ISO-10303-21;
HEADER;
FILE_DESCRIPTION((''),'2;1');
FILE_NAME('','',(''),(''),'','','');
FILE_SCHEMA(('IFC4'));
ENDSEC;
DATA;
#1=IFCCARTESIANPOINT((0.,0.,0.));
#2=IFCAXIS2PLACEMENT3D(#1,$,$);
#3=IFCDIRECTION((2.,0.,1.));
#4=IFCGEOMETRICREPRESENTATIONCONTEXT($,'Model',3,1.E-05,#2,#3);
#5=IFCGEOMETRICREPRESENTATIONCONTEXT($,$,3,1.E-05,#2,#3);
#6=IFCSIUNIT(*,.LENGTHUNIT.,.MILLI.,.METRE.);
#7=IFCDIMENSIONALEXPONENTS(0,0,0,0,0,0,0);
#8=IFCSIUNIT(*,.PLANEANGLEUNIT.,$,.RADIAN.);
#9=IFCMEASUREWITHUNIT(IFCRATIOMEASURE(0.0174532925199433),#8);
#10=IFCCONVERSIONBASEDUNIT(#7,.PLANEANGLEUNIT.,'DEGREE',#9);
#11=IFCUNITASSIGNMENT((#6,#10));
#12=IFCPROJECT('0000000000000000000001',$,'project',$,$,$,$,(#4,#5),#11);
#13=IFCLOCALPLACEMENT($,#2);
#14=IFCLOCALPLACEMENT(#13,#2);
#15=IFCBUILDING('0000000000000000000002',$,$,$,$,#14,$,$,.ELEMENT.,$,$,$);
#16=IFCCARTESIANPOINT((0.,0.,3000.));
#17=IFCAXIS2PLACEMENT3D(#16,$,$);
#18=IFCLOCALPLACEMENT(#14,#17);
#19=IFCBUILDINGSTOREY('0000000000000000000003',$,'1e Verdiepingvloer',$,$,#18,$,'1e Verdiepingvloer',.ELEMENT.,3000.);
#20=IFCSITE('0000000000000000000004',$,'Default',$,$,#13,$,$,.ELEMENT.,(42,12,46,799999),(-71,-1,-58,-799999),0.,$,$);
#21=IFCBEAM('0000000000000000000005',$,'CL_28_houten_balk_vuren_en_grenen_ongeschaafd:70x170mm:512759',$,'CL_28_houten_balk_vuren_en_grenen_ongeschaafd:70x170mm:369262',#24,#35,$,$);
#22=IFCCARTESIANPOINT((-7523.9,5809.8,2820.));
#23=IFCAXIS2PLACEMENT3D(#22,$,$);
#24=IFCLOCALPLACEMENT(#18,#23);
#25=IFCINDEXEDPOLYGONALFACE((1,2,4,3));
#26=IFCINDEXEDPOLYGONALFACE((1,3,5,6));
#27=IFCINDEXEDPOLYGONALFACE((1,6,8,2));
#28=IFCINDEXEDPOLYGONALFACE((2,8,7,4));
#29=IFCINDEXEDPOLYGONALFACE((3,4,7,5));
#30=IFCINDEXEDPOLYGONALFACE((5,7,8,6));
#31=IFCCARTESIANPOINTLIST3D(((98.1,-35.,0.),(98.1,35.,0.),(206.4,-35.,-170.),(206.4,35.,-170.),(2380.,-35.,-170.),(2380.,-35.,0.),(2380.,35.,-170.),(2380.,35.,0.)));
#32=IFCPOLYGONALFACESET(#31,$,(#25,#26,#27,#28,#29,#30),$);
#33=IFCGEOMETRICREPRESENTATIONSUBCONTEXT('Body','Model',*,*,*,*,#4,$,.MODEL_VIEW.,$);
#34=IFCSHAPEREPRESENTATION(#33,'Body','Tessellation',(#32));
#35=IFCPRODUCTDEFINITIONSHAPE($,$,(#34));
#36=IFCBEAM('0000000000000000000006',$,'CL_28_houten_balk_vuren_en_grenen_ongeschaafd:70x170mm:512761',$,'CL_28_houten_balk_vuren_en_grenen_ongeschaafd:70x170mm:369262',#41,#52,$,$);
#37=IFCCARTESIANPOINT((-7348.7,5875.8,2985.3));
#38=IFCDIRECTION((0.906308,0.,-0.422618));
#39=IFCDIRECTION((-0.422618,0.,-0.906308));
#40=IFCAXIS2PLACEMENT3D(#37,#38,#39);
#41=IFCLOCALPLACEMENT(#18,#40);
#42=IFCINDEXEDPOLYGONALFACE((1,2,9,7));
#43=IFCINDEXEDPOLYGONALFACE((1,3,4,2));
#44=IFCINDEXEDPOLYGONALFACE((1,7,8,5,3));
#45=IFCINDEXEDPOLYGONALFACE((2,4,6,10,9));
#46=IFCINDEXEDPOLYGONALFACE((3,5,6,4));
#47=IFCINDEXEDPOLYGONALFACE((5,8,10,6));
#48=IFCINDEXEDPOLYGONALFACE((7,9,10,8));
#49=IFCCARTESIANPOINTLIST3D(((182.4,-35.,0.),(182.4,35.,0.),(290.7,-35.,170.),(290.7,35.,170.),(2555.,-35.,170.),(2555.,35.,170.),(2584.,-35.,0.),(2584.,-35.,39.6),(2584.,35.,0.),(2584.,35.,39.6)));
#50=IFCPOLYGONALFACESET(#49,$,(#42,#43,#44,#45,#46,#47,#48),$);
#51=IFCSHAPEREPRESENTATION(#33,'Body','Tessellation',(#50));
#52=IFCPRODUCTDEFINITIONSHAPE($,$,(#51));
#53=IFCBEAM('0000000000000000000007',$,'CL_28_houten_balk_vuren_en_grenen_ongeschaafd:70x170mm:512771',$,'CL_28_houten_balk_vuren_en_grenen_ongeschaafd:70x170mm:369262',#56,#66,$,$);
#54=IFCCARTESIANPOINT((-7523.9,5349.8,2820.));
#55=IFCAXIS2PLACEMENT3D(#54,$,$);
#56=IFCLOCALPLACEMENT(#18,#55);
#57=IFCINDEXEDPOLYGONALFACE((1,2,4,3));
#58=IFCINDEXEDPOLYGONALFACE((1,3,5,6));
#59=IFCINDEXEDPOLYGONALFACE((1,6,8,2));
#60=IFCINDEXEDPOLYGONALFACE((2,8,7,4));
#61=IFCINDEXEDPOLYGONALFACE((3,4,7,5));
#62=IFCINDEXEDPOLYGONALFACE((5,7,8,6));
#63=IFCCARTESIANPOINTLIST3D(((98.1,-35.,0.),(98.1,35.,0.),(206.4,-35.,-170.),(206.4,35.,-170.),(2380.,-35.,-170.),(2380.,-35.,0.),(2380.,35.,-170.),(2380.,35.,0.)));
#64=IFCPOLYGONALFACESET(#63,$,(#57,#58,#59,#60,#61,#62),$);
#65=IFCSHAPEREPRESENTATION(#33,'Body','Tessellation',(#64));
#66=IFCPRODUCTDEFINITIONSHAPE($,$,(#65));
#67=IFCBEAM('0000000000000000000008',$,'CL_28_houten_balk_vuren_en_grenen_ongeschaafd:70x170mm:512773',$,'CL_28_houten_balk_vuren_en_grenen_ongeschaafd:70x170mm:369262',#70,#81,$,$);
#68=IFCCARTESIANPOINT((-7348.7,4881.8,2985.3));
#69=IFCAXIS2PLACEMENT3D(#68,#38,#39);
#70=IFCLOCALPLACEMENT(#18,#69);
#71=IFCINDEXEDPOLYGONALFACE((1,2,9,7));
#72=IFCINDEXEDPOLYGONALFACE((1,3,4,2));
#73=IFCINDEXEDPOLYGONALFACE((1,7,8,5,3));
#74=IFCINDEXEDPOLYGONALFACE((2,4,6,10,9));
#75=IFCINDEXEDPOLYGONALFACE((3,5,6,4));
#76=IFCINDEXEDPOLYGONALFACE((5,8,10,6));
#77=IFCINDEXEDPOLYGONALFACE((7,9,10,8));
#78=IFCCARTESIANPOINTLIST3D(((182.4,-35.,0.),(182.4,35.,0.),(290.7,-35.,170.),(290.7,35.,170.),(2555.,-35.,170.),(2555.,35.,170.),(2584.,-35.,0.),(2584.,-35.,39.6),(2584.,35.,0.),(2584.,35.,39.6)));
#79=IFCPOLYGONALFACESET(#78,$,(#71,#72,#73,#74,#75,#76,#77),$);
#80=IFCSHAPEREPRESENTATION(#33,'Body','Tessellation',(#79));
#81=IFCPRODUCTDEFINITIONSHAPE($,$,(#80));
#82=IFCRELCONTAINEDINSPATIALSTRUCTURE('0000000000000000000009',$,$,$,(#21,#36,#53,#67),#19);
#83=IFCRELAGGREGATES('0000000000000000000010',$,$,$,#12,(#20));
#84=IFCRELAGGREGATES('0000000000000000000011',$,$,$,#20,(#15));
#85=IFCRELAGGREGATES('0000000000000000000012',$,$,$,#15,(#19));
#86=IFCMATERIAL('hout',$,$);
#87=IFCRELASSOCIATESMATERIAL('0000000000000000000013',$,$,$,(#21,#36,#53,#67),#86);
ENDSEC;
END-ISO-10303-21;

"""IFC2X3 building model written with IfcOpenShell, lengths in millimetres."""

from ifc_helpers import new_model, entity, si_unit, converted_unit, direction, frame, frame_2d, origin, place, context, subcontext, project, spatial, rectangle, extrude, clip, halfspace, material, element, save


model = new_model("IFC2X3")

# Units and contexts
model_context = context("Model", 3, precision=1e-05, world=origin(), true_north=direction((2.0, 0.0, 1.0)))
context_of_model = context(None, 3, precision=1e-05, world=origin(), true_north=direction((2.0, 0.0, 1.0)))
body_context = subcontext(model_context, "Body", "Model", "MODEL_VIEW")
ifc_project = project(units=[si_unit("LENGTHUNIT", "METRE", prefix="MILLI"), converted_unit("PLANEANGLEUNIT", "DEGREE", entity("IfcRatioMeasure", 0.0174532925199433), si_unit("PLANEANGLEUNIT", "RADIAN"), dimensions=[0, 0, 0, 0, 0, 0, 0])], contexts=[model_context, context_of_model])

# Site, building, storey
site_placement = place(None, origin())
site = spatial("IfcSite", under=ifc_project, at=site_placement, Name="Default", CompositionType="ELEMENT", RefLatitude=(42, 12, 46, 799999), RefLongitude=(-71, -1, -58, -799999), RefElevation=0.0)
building_placement = place(site_placement, origin())
building = spatial("IfcBuilding", under=site, at=building_placement, CompositionType="ELEMENT")
storey_placement = place(building_placement, frame((0.0, 0.0, 3000.0)))
storey = spatial("IfcBuildingStorey", under=building, at=storey_placement, Name="1e Verdiepingvloer", LongName="1e Verdiepingvloer", CompositionType="ELEMENT", Elevation=3000.0)

# Beams
ifc_material_1 = material(Name="hout")
beam_1_placement = place(storey_placement, frame((-7523.9, 5809.8, 2820.0)))
element("IfcBeam", 1, at=beam_1_placement, inside=storey, material=ifc_material_1, Name="CL_28_houten_balk_vuren_en_grenen_ongeschaafd:70x170mm:512759", ObjectType="CL_28_houten_balk_vuren_en_grenen_ongeschaafd:70x170mm:369262", context=body_context, shape_type="Clipping", body=[
    clip(extrude(rectangle(XDim=170.0, YDim=70.0, at=frame_2d((0.0, 0.0), x_axis=(1.0, 0.0))), frame((98.1, 0.0, -85.0), z_axis=(1.0, 0.0, 0.0), x_axis=(0.0, 0.0, -1.0)), (0.0, 0.0, 1.0), 2281.9), halfspace(frame((206.4, -73.2, -170.0), z_axis=(-0.843391, 0.0, -0.5373), x_axis=(0.5373, 0.0, -0.843391)), False)),
])
beam_2_placement = place(storey_placement, frame((-7348.7, 5875.8, 2985.3), z_axis=(0.906308, 0.0, -0.422618), x_axis=(-0.422618, 0.0, -0.906308)))
element("IfcBeam", 2, at=beam_2_placement, inside=storey, material=ifc_material_1, Name="CL_28_houten_balk_vuren_en_grenen_ongeschaafd:70x170mm:512761", ObjectType="CL_28_houten_balk_vuren_en_grenen_ongeschaafd:70x170mm:369262", context=body_context, shape_type="Clipping", body=[
    clip(clip(extrude(rectangle(XDim=170.0, YDim=70.0, at=frame_2d((0.0, 0.0), x_axis=(0.0, 1.0))), frame((182.4, 0.0, 85.0), z_axis=(1.0, 0.0, 0.0), x_axis=(0.0, 1.0, 0.0)), (0.0, 0.0, 1.0), 2401.5), halfspace(frame((2590.9, -1438.2, 8.5), z_axis=(0.976296, 0.0, 0.21644), x_axis=(-0.21644, 0.0, 0.976296)), False)), halfspace(frame((290.7, -139.2, 170.0), z_axis=(-0.843391, 0.0, 0.5373), x_axis=(0.5373, 0.0, 0.843391)), False)),
])
beam_3_placement = place(storey_placement, frame((-7523.9, 5349.8, 2820.0)))
element("IfcBeam", 3, at=beam_3_placement, inside=storey, material=ifc_material_1, Name="CL_28_houten_balk_vuren_en_grenen_ongeschaafd:70x170mm:512771", ObjectType="CL_28_houten_balk_vuren_en_grenen_ongeschaafd:70x170mm:369262", context=body_context, shape_type="Clipping", body=[
    clip(extrude(rectangle(XDim=170.0, YDim=70.0, at=frame_2d((0.0, 0.0), x_axis=(1.0, 0.0))), frame((98.1, 0.0, -85.0), z_axis=(1.0, 0.0, 0.0), x_axis=(0.0, 0.0, -1.0)), (0.0, 0.0, 1.0), 2281.9), halfspace(frame((206.4, 386.8, -170.0), z_axis=(-0.843391, 0.0, -0.5373), x_axis=(0.5373, 0.0, -0.843391)), False)),
])
beam_4_placement = place(storey_placement, frame((-7348.7, 4881.8, 2985.3), z_axis=(0.906308, 0.0, -0.422618), x_axis=(-0.422618, 0.0, -0.906308)))
element("IfcBeam", 4, at=beam_4_placement, inside=storey, material=ifc_material_1, Name="CL_28_houten_balk_vuren_en_grenen_ongeschaafd:70x170mm:512773", ObjectType="CL_28_houten_balk_vuren_en_grenen_ongeschaafd:70x170mm:369262", context=body_context, shape_type="Clipping", body=[
    clip(clip(extrude(rectangle(XDim=170.0, YDim=70.0, at=frame_2d((0.0, 0.0), x_axis=(0.0, 1.0))), frame((182.4, 0.0, 85.0), z_axis=(1.0, 0.0, 0.0), x_axis=(0.0, 1.0, 0.0)), (0.0, 0.0, 1.0), 2401.5), halfspace(frame((2590.9, -444.2, 8.5), z_axis=(0.976296, 0.0, 0.21644), x_axis=(-0.21644, 0.0, 0.976296)), False)), halfspace(frame((290.7, 854.8, 170.0), z_axis=(-0.843391, 0.0, 0.5373), x_axis=(0.5373, 0.0, 0.843391)), False)),
])

save(model, "model.ifc")
